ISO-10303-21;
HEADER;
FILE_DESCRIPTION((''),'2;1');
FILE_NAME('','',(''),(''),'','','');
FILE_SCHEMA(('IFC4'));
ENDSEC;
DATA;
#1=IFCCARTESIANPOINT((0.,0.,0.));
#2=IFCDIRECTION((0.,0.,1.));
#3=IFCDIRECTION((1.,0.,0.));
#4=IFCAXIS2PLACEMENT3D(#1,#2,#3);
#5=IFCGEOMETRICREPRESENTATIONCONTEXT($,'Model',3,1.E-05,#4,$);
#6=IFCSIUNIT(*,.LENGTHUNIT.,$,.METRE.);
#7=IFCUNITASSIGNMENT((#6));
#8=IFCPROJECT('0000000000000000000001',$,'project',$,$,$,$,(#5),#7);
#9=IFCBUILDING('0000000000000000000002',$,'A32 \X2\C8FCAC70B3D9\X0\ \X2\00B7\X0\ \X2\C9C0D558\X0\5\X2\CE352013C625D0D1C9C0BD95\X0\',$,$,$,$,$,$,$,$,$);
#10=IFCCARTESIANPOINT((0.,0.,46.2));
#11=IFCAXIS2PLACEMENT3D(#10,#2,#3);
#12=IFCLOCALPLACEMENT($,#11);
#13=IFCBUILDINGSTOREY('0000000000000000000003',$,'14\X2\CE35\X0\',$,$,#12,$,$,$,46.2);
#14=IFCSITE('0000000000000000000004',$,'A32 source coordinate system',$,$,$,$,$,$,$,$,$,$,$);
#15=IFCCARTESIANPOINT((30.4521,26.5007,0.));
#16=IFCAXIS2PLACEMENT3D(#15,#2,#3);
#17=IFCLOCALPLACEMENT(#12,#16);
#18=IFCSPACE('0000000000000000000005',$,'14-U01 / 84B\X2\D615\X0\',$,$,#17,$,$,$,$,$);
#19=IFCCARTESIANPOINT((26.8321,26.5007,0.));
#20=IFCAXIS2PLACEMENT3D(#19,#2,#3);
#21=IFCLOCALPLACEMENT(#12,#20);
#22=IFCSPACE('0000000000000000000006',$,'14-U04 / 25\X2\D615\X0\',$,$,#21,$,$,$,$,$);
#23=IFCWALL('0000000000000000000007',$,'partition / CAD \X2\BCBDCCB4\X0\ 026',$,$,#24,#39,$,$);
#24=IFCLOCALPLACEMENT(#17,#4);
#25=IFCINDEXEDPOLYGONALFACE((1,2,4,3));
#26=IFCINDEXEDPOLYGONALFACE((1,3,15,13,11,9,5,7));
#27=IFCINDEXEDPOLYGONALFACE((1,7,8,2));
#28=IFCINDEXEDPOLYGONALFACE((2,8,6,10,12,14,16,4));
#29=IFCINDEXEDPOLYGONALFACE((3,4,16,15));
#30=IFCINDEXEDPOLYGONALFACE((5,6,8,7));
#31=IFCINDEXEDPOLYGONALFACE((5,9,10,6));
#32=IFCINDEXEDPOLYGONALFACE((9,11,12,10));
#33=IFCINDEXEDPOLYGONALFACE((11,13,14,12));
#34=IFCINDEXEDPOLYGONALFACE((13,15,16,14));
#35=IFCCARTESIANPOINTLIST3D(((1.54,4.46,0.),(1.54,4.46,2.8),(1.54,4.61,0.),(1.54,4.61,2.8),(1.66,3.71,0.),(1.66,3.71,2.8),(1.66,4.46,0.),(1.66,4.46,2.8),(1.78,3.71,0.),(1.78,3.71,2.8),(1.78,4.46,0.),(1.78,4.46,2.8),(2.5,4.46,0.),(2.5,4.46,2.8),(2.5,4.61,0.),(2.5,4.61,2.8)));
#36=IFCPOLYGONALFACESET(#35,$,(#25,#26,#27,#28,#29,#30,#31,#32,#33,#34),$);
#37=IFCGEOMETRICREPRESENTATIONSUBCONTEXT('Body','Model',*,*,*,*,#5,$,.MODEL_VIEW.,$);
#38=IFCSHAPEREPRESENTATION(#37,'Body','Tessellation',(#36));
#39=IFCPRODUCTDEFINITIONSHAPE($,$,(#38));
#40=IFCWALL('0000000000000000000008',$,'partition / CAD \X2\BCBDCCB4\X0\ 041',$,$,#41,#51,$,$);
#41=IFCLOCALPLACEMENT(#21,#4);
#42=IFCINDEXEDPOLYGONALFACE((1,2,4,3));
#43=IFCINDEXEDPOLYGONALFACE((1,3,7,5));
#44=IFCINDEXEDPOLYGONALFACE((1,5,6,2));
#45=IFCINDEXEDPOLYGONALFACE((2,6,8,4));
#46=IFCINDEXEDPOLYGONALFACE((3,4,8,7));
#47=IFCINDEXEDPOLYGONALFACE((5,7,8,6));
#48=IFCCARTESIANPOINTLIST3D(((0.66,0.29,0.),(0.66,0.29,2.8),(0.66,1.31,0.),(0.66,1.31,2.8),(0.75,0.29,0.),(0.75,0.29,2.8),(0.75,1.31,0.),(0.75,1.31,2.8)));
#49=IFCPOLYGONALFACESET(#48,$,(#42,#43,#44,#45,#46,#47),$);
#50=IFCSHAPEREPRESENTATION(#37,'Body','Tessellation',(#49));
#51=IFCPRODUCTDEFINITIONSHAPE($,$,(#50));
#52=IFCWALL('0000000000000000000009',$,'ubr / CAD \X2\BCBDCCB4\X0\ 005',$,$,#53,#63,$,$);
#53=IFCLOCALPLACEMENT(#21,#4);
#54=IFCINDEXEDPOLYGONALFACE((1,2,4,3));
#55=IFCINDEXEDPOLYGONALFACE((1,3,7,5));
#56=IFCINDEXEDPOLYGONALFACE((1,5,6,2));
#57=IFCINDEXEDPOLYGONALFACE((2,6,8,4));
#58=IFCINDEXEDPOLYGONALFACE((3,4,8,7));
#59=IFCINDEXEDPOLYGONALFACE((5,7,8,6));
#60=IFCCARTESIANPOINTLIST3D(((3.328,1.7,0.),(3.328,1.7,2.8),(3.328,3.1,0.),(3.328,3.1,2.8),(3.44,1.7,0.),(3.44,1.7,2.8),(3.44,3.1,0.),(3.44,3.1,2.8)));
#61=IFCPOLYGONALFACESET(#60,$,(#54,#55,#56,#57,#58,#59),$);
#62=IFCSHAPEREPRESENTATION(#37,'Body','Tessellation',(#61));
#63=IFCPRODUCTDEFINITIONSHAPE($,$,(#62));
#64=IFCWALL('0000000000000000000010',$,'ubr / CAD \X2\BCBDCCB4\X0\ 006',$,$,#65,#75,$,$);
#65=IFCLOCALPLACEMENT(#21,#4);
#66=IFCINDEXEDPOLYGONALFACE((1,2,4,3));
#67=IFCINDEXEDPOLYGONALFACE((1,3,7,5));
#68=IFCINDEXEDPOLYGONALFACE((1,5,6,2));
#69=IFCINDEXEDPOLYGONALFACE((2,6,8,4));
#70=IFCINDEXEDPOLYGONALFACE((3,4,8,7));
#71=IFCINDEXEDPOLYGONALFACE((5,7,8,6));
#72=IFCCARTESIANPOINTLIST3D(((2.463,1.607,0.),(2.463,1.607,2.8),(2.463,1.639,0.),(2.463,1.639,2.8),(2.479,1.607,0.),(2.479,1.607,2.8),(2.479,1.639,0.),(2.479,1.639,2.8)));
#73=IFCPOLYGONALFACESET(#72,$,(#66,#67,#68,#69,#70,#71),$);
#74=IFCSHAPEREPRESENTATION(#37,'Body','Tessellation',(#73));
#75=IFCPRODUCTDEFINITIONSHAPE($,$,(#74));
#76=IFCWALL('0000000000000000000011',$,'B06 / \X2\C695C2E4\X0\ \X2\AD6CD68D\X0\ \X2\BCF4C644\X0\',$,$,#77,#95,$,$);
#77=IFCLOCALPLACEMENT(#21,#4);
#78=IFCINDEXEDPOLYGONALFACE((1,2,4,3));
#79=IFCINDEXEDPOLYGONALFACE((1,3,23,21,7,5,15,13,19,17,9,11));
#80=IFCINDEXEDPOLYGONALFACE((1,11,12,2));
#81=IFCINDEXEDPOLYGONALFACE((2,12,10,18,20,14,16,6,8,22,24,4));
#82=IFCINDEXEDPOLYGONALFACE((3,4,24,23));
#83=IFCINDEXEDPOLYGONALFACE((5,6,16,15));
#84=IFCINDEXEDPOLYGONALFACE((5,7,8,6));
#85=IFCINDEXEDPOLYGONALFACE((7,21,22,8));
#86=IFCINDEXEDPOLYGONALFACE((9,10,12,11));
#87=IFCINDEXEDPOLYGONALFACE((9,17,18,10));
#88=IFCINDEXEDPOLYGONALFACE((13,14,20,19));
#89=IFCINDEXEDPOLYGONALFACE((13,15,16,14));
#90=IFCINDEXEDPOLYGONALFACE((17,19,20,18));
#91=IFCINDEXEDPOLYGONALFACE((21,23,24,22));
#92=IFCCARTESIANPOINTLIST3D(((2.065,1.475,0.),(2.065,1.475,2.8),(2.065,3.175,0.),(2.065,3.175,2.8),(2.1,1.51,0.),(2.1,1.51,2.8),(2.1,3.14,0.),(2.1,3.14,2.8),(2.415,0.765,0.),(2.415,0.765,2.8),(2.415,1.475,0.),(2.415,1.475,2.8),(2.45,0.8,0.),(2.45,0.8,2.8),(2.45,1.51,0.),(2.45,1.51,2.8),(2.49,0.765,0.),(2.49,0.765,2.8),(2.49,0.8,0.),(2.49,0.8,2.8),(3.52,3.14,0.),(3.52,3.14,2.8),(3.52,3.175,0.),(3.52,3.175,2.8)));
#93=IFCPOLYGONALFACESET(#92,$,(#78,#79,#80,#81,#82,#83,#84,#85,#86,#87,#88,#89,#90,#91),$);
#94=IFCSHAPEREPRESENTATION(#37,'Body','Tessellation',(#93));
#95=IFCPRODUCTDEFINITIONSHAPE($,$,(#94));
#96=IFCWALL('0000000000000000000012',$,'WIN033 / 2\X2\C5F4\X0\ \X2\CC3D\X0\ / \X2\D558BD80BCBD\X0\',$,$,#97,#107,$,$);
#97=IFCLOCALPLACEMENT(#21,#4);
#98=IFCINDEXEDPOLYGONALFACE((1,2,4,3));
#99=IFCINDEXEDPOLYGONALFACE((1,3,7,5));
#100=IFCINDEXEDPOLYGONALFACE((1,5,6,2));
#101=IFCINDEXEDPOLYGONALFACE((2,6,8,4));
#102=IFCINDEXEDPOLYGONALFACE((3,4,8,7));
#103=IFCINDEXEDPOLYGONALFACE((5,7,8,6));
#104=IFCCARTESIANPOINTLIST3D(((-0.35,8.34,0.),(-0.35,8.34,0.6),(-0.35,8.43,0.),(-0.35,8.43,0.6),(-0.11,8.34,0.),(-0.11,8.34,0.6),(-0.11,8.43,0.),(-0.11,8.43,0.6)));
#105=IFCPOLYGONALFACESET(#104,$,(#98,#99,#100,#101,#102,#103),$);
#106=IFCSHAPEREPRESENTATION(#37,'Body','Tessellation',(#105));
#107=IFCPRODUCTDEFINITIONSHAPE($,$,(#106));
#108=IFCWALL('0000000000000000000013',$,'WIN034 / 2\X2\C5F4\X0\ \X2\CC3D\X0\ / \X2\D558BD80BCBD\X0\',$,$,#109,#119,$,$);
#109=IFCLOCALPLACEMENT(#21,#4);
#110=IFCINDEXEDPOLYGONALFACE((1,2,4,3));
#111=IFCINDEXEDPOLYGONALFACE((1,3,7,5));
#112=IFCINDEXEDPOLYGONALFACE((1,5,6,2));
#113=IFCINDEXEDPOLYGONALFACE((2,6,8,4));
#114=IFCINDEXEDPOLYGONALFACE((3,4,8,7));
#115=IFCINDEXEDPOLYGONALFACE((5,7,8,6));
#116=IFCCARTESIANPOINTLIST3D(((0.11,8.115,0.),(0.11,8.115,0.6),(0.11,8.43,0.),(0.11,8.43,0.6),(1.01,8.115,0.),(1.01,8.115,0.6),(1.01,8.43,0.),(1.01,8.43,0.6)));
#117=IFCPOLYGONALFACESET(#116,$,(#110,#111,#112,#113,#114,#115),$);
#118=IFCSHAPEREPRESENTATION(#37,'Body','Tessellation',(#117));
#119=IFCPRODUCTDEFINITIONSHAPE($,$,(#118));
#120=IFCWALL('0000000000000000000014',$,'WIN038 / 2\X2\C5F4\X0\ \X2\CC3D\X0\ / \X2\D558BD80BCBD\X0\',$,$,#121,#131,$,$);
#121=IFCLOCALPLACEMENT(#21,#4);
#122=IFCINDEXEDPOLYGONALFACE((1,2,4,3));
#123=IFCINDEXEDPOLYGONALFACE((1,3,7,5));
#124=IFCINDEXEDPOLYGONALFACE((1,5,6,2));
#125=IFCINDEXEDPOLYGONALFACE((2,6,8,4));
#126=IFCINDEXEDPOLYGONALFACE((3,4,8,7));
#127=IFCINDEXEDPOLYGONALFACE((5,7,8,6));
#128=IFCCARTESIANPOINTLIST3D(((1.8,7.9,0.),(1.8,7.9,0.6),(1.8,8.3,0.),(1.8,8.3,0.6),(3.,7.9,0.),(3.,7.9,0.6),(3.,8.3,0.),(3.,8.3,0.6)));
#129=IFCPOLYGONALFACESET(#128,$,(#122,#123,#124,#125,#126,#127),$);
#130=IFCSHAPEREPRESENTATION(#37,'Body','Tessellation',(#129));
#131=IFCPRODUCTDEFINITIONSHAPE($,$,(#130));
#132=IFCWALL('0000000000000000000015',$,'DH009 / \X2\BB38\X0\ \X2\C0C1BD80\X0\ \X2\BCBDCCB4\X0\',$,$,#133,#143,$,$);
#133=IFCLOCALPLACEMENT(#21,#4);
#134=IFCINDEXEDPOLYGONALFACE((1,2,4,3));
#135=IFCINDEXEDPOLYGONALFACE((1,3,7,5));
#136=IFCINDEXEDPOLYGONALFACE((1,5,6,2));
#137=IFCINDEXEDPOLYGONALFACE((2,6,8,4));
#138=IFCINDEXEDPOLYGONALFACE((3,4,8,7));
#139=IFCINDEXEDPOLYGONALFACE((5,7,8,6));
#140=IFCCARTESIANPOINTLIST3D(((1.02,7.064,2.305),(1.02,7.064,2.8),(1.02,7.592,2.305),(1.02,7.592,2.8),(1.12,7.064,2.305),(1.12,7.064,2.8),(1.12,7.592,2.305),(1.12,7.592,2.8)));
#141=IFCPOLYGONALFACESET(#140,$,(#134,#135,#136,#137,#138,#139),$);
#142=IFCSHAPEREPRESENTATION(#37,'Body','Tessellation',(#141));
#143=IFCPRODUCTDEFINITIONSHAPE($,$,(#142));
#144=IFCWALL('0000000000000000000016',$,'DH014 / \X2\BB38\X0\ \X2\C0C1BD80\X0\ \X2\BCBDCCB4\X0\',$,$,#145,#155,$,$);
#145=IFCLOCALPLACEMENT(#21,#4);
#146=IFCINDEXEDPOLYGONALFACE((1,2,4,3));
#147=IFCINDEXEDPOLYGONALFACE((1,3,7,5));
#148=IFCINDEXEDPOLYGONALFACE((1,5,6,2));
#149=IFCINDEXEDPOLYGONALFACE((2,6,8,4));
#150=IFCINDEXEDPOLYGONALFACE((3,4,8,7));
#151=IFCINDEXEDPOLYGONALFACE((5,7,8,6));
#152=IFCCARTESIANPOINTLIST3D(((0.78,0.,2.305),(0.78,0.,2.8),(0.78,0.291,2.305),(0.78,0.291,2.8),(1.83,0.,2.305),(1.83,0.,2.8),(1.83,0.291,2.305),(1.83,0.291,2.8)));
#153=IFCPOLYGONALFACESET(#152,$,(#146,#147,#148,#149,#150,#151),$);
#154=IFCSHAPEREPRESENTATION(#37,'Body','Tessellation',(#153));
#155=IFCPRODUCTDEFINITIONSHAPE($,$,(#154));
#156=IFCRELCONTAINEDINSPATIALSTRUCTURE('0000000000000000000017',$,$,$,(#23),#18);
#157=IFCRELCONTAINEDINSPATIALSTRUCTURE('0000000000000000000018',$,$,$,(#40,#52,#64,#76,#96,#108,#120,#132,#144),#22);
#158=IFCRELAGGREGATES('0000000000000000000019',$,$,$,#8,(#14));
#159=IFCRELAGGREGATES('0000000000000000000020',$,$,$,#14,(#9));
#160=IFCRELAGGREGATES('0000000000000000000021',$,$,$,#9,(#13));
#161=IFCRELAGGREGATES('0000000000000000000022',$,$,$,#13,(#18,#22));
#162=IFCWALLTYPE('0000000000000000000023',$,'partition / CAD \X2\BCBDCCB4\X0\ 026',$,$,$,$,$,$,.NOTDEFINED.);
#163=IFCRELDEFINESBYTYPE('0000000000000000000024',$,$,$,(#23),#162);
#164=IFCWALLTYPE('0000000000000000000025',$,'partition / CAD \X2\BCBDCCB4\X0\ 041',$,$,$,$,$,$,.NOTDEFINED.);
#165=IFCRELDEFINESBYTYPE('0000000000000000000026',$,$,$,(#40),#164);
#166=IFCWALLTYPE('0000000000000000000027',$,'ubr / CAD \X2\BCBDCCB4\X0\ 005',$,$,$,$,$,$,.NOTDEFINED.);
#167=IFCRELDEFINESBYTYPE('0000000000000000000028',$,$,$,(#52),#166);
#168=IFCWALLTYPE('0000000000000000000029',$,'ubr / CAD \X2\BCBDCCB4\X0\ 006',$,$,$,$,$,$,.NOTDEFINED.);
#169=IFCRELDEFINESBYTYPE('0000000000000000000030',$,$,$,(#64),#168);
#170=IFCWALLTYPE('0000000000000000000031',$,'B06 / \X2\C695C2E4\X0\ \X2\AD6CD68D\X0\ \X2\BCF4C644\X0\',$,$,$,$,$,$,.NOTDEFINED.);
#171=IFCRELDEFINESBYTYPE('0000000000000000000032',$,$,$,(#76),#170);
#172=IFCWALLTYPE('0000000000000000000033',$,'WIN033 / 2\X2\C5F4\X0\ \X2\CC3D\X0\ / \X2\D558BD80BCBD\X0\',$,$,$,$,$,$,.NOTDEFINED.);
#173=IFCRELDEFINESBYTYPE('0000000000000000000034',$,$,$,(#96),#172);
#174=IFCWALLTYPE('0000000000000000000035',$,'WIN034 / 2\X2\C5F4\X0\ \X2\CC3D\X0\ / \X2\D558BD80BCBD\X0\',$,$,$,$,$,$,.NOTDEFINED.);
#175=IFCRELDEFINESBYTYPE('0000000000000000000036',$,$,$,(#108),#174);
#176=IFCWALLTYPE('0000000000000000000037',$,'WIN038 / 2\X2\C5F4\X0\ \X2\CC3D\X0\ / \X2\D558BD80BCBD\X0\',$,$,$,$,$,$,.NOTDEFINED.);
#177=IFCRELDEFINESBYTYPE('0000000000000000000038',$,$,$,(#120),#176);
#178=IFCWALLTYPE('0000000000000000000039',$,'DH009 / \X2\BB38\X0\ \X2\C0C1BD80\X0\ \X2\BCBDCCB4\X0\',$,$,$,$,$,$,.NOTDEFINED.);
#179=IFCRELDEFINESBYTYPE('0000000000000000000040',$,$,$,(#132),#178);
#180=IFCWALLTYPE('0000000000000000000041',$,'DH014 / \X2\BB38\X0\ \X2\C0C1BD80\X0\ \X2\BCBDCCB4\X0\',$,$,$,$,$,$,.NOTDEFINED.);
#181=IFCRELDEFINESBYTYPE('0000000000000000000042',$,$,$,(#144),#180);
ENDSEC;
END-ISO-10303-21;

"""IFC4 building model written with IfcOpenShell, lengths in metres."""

from ifc_helpers import new_model, si_unit, frame, origin, origin_with_axes, place, context, subcontext, project, spatial, polyline, outline, extrude, source, transform, mapped, type_object, type_shapes, element, save


model = new_model("IFC4")

# Units and contexts
model_context = context("Model", 3, precision=1e-05, world=origin_with_axes())
body_context = subcontext(model_context, "Body", "Model", "MODEL_VIEW")
ifc_project = project(units=[si_unit("LENGTHUNIT", "METRE")], contexts=[model_context])

# Site, building, storey, space
site = spatial("IfcSite", under=ifc_project, Name="A32 source coordinate system")
building = spatial("IfcBuilding", under=site, Name="A32 주거동 · 지하5층–옥탑지붕")
storey_placement = place(None, frame((0.0, 0.0, 46.2), z_axis=(0.0, 0.0, 1.0), x_axis=(1.0, 0.0, 0.0)))
storey = spatial("IfcBuildingStorey", under=building, at=storey_placement, Name="14층", Elevation=46.2)
space_1_placement = place(storey_placement, frame((30.4521, 26.5007, 0.0), z_axis=(0.0, 0.0, 1.0), x_axis=(1.0, 0.0, 0.0)))
space_1 = spatial("IfcSpace", under=storey, at=space_1_placement, Name="14-U01 / 84B형")

# Wall
wall_type_1 = type_object("IfcWallType", Name="partition / CAD 벽체 026", PredefinedType="NOTDEFINED")
shared_shape_1 = source(origin(), body_context, "Body", "SweptSolid", [
    extrude(outline(polyline([(1.54, 4.46), (1.54, 4.61), (2.5, 4.61), (2.5, 4.46), (1.78, 4.46), (1.78, 3.71), (1.66, 3.71), (1.66, 4.46), (1.54, 4.46)])), origin(), (0.0, 0.0, 1.0), 2.8),
])
type_shapes(wall_type_1, [shared_shape_1])
wall_1_placement = place(space_1_placement, origin_with_axes())
element("IfcWall", 1, at=wall_1_placement, inside=space_1, type_object=wall_type_1, Name="partition / CAD 벽체 026", context=body_context, shape_type="MappedRepresentation", body=[
    mapped(shared_shape_1, transform((0.0, 0.0, 0.0), scale=1.0)),
])

# Shared definitions
space_2_placement = place(storey_placement, frame((26.8321, 26.5007, 0.0), z_axis=(0.0, 0.0, 1.0), x_axis=(1.0, 0.0, 0.0)))
space_2 = spatial("IfcSpace", under=storey, at=space_2_placement, Name="14-U04 / 25형")

# Walls
wall_type_2 = type_object("IfcWallType", Name="partition / CAD 벽체 041", PredefinedType="NOTDEFINED")
shared_shape_2 = source(origin(), body_context, "Body", "SweptSolid", [
    extrude(outline(polyline([(0.75, 1.31), (0.75, 0.29), (0.66, 0.29), (0.66, 1.31), (0.75, 1.31)])), origin(), (0.0, 0.0, 1.0), 2.8),
])
type_shapes(wall_type_2, [shared_shape_2])
wall_2_placement = place(space_2_placement, origin_with_axes())
element("IfcWall", 2, at=wall_2_placement, inside=space_2, type_object=wall_type_2, Name="partition / CAD 벽체 041", context=body_context, shape_type="MappedRepresentation", body=[
    mapped(shared_shape_2, transform((0.0, 0.0, 0.0), scale=1.0)),
])
wall_type_3 = type_object("IfcWallType", Name="ubr / CAD 벽체 005", PredefinedType="NOTDEFINED")
shared_shape_3 = source(origin(), body_context, "Body", "SweptSolid", [
    extrude(outline(polyline([(3.44, 3.1), (3.44, 1.7), (3.328, 1.7), (3.328, 3.1), (3.44, 3.1)])), origin(), (0.0, 0.0, 1.0), 2.8),
])
type_shapes(wall_type_3, [shared_shape_3])
wall_3_placement = place(space_2_placement, origin_with_axes())
element("IfcWall", 3, at=wall_3_placement, inside=space_2, type_object=wall_type_3, Name="ubr / CAD 벽체 005", context=body_context, shape_type="MappedRepresentation", body=[
    mapped(shared_shape_3, transform((0.0, 0.0, 0.0), scale=1.0)),
])
wall_type_4 = type_object("IfcWallType", Name="ubr / CAD 벽체 006", PredefinedType="NOTDEFINED")
shared_shape_4 = source(origin(), body_context, "Body", "SweptSolid", [
    extrude(outline(polyline([(2.463, 1.639), (2.479, 1.639), (2.479, 1.607), (2.463, 1.607), (2.463, 1.639)])), origin(), (0.0, 0.0, 1.0), 2.8),
])
type_shapes(wall_type_4, [shared_shape_4])
wall_4_placement = place(space_2_placement, origin_with_axes())
element("IfcWall", 4, at=wall_4_placement, inside=space_2, type_object=wall_type_4, Name="ubr / CAD 벽체 006", context=body_context, shape_type="MappedRepresentation", body=[
    mapped(shared_shape_4, transform((0.0, 0.0, 0.0), scale=1.0)),
])
wall_type_5 = type_object("IfcWallType", Name="B06 / 욕실 구획 보완", PredefinedType="NOTDEFINED")
shared_shape_5 = source(origin(), body_context, "Body", "SweptSolid", [
    extrude(outline(polyline([(3.52, 3.14), (2.1, 3.14), (2.1, 1.51), (2.45, 1.51), (2.45, 0.8), (2.49, 0.8), (2.49, 0.765), (2.415, 0.765), (2.415, 1.475), (2.065, 1.475), (2.065, 3.175), (3.52, 3.175), (3.52, 3.14)])), origin(), (0.0, 0.0, 1.0), 2.8),
])
type_shapes(wall_type_5, [shared_shape_5])
wall_5_placement = place(space_2_placement, origin_with_axes())
element("IfcWall", 5, at=wall_5_placement, inside=space_2, type_object=wall_type_5, Name="B06 / 욕실 구획 보완", context=body_context, shape_type="MappedRepresentation", body=[
    mapped(shared_shape_5, transform((0.0, 0.0, 0.0), scale=1.0)),
])
wall_type_6 = type_object("IfcWallType", Name="WIN033 / 2열 창 / 하부벽", PredefinedType="NOTDEFINED")
shared_shape_6 = source(origin(), body_context, "Body", "SweptSolid", [
    extrude(outline(polyline([(-0.11, 8.43), (-0.11, 8.34), (-0.35, 8.34), (-0.35, 8.43), (-0.11, 8.43)])), origin(), (0.0, 0.0, 1.0), 0.6),
])
type_shapes(wall_type_6, [shared_shape_6])
wall_6_placement = place(space_2_placement, origin_with_axes())
element("IfcWall", 6, at=wall_6_placement, inside=space_2, type_object=wall_type_6, Name="WIN033 / 2열 창 / 하부벽", context=body_context, shape_type="MappedRepresentation", body=[
    mapped(shared_shape_6, transform((0.0, 0.0, 0.0), scale=1.0)),
])
wall_type_7 = type_object("IfcWallType", Name="WIN034 / 2열 창 / 하부벽", PredefinedType="NOTDEFINED")
shared_shape_7 = source(origin(), body_context, "Body", "SweptSolid", [
    extrude(outline(polyline([(0.11, 8.115), (0.11, 8.43), (1.01, 8.43), (1.01, 8.115), (0.11, 8.115)])), origin(), (0.0, 0.0, 1.0), 0.6),
])
type_shapes(wall_type_7, [shared_shape_7])
wall_7_placement = place(space_2_placement, origin_with_axes())
element("IfcWall", 7, at=wall_7_placement, inside=space_2, type_object=wall_type_7, Name="WIN034 / 2열 창 / 하부벽", context=body_context, shape_type="MappedRepresentation", body=[
    mapped(shared_shape_7, transform((0.0, 0.0, 0.0), scale=1.0)),
])
wall_type_8 = type_object("IfcWallType", Name="WIN038 / 2열 창 / 하부벽", PredefinedType="NOTDEFINED")
shared_shape_8 = source(origin(), body_context, "Body", "SweptSolid", [
    extrude(outline(polyline([(1.8, 7.9), (1.8, 8.3), (3.0, 8.3), (3.0, 7.9), (1.8, 7.9)])), origin(), (0.0, 0.0, 1.0), 0.6),
])
type_shapes(wall_type_8, [shared_shape_8])
wall_8_placement = place(space_2_placement, origin_with_axes())
element("IfcWall", 8, at=wall_8_placement, inside=space_2, type_object=wall_type_8, Name="WIN038 / 2열 창 / 하부벽", context=body_context, shape_type="MappedRepresentation", body=[
    mapped(shared_shape_8, transform((0.0, 0.0, 0.0), scale=1.0)),
])
wall_type_9 = type_object("IfcWallType", Name="DH009 / 문 상부 벽체", PredefinedType="NOTDEFINED")
shared_shape_9 = source(origin(), body_context, "Body", "SweptSolid", [
    extrude(outline(polyline([(1.02, 7.064), (1.02, 7.592), (1.12, 7.592), (1.12, 7.064), (1.02, 7.064)])), frame((0.0, 0.0, 2.305)), (0.0, 0.0, 1.0), 0.495),
])
type_shapes(wall_type_9, [shared_shape_9])
wall_9_placement = place(space_2_placement, origin_with_axes())
element("IfcWall", 9, at=wall_9_placement, inside=space_2, type_object=wall_type_9, Name="DH009 / 문 상부 벽체", context=body_context, shape_type="MappedRepresentation", body=[
    mapped(shared_shape_9, transform((0.0, 0.0, 0.0), scale=1.0)),
])
wall_type_10 = type_object("IfcWallType", Name="DH014 / 문 상부 벽체", PredefinedType="NOTDEFINED")
shared_shape_10 = source(origin(), body_context, "Body", "SweptSolid", [
    extrude(outline(polyline([(0.78, 0.291), (1.83, 0.291), (1.83, 0.0), (0.78, 0.0), (0.78, 0.291)])), frame((0.0, 0.0, 2.305)), (0.0, 0.0, 1.0), 0.495),
])
type_shapes(wall_type_10, [shared_shape_10])
wall_10_placement = place(space_2_placement, origin_with_axes())
element("IfcWall", 10, at=wall_10_placement, inside=space_2, type_object=wall_type_10, Name="DH014 / 문 상부 벽체", context=body_context, shape_type="MappedRepresentation", body=[
    mapped(shared_shape_10, transform((0.0, 0.0, 0.0), scale=1.0)),
])

save(model, "model.ifc")
